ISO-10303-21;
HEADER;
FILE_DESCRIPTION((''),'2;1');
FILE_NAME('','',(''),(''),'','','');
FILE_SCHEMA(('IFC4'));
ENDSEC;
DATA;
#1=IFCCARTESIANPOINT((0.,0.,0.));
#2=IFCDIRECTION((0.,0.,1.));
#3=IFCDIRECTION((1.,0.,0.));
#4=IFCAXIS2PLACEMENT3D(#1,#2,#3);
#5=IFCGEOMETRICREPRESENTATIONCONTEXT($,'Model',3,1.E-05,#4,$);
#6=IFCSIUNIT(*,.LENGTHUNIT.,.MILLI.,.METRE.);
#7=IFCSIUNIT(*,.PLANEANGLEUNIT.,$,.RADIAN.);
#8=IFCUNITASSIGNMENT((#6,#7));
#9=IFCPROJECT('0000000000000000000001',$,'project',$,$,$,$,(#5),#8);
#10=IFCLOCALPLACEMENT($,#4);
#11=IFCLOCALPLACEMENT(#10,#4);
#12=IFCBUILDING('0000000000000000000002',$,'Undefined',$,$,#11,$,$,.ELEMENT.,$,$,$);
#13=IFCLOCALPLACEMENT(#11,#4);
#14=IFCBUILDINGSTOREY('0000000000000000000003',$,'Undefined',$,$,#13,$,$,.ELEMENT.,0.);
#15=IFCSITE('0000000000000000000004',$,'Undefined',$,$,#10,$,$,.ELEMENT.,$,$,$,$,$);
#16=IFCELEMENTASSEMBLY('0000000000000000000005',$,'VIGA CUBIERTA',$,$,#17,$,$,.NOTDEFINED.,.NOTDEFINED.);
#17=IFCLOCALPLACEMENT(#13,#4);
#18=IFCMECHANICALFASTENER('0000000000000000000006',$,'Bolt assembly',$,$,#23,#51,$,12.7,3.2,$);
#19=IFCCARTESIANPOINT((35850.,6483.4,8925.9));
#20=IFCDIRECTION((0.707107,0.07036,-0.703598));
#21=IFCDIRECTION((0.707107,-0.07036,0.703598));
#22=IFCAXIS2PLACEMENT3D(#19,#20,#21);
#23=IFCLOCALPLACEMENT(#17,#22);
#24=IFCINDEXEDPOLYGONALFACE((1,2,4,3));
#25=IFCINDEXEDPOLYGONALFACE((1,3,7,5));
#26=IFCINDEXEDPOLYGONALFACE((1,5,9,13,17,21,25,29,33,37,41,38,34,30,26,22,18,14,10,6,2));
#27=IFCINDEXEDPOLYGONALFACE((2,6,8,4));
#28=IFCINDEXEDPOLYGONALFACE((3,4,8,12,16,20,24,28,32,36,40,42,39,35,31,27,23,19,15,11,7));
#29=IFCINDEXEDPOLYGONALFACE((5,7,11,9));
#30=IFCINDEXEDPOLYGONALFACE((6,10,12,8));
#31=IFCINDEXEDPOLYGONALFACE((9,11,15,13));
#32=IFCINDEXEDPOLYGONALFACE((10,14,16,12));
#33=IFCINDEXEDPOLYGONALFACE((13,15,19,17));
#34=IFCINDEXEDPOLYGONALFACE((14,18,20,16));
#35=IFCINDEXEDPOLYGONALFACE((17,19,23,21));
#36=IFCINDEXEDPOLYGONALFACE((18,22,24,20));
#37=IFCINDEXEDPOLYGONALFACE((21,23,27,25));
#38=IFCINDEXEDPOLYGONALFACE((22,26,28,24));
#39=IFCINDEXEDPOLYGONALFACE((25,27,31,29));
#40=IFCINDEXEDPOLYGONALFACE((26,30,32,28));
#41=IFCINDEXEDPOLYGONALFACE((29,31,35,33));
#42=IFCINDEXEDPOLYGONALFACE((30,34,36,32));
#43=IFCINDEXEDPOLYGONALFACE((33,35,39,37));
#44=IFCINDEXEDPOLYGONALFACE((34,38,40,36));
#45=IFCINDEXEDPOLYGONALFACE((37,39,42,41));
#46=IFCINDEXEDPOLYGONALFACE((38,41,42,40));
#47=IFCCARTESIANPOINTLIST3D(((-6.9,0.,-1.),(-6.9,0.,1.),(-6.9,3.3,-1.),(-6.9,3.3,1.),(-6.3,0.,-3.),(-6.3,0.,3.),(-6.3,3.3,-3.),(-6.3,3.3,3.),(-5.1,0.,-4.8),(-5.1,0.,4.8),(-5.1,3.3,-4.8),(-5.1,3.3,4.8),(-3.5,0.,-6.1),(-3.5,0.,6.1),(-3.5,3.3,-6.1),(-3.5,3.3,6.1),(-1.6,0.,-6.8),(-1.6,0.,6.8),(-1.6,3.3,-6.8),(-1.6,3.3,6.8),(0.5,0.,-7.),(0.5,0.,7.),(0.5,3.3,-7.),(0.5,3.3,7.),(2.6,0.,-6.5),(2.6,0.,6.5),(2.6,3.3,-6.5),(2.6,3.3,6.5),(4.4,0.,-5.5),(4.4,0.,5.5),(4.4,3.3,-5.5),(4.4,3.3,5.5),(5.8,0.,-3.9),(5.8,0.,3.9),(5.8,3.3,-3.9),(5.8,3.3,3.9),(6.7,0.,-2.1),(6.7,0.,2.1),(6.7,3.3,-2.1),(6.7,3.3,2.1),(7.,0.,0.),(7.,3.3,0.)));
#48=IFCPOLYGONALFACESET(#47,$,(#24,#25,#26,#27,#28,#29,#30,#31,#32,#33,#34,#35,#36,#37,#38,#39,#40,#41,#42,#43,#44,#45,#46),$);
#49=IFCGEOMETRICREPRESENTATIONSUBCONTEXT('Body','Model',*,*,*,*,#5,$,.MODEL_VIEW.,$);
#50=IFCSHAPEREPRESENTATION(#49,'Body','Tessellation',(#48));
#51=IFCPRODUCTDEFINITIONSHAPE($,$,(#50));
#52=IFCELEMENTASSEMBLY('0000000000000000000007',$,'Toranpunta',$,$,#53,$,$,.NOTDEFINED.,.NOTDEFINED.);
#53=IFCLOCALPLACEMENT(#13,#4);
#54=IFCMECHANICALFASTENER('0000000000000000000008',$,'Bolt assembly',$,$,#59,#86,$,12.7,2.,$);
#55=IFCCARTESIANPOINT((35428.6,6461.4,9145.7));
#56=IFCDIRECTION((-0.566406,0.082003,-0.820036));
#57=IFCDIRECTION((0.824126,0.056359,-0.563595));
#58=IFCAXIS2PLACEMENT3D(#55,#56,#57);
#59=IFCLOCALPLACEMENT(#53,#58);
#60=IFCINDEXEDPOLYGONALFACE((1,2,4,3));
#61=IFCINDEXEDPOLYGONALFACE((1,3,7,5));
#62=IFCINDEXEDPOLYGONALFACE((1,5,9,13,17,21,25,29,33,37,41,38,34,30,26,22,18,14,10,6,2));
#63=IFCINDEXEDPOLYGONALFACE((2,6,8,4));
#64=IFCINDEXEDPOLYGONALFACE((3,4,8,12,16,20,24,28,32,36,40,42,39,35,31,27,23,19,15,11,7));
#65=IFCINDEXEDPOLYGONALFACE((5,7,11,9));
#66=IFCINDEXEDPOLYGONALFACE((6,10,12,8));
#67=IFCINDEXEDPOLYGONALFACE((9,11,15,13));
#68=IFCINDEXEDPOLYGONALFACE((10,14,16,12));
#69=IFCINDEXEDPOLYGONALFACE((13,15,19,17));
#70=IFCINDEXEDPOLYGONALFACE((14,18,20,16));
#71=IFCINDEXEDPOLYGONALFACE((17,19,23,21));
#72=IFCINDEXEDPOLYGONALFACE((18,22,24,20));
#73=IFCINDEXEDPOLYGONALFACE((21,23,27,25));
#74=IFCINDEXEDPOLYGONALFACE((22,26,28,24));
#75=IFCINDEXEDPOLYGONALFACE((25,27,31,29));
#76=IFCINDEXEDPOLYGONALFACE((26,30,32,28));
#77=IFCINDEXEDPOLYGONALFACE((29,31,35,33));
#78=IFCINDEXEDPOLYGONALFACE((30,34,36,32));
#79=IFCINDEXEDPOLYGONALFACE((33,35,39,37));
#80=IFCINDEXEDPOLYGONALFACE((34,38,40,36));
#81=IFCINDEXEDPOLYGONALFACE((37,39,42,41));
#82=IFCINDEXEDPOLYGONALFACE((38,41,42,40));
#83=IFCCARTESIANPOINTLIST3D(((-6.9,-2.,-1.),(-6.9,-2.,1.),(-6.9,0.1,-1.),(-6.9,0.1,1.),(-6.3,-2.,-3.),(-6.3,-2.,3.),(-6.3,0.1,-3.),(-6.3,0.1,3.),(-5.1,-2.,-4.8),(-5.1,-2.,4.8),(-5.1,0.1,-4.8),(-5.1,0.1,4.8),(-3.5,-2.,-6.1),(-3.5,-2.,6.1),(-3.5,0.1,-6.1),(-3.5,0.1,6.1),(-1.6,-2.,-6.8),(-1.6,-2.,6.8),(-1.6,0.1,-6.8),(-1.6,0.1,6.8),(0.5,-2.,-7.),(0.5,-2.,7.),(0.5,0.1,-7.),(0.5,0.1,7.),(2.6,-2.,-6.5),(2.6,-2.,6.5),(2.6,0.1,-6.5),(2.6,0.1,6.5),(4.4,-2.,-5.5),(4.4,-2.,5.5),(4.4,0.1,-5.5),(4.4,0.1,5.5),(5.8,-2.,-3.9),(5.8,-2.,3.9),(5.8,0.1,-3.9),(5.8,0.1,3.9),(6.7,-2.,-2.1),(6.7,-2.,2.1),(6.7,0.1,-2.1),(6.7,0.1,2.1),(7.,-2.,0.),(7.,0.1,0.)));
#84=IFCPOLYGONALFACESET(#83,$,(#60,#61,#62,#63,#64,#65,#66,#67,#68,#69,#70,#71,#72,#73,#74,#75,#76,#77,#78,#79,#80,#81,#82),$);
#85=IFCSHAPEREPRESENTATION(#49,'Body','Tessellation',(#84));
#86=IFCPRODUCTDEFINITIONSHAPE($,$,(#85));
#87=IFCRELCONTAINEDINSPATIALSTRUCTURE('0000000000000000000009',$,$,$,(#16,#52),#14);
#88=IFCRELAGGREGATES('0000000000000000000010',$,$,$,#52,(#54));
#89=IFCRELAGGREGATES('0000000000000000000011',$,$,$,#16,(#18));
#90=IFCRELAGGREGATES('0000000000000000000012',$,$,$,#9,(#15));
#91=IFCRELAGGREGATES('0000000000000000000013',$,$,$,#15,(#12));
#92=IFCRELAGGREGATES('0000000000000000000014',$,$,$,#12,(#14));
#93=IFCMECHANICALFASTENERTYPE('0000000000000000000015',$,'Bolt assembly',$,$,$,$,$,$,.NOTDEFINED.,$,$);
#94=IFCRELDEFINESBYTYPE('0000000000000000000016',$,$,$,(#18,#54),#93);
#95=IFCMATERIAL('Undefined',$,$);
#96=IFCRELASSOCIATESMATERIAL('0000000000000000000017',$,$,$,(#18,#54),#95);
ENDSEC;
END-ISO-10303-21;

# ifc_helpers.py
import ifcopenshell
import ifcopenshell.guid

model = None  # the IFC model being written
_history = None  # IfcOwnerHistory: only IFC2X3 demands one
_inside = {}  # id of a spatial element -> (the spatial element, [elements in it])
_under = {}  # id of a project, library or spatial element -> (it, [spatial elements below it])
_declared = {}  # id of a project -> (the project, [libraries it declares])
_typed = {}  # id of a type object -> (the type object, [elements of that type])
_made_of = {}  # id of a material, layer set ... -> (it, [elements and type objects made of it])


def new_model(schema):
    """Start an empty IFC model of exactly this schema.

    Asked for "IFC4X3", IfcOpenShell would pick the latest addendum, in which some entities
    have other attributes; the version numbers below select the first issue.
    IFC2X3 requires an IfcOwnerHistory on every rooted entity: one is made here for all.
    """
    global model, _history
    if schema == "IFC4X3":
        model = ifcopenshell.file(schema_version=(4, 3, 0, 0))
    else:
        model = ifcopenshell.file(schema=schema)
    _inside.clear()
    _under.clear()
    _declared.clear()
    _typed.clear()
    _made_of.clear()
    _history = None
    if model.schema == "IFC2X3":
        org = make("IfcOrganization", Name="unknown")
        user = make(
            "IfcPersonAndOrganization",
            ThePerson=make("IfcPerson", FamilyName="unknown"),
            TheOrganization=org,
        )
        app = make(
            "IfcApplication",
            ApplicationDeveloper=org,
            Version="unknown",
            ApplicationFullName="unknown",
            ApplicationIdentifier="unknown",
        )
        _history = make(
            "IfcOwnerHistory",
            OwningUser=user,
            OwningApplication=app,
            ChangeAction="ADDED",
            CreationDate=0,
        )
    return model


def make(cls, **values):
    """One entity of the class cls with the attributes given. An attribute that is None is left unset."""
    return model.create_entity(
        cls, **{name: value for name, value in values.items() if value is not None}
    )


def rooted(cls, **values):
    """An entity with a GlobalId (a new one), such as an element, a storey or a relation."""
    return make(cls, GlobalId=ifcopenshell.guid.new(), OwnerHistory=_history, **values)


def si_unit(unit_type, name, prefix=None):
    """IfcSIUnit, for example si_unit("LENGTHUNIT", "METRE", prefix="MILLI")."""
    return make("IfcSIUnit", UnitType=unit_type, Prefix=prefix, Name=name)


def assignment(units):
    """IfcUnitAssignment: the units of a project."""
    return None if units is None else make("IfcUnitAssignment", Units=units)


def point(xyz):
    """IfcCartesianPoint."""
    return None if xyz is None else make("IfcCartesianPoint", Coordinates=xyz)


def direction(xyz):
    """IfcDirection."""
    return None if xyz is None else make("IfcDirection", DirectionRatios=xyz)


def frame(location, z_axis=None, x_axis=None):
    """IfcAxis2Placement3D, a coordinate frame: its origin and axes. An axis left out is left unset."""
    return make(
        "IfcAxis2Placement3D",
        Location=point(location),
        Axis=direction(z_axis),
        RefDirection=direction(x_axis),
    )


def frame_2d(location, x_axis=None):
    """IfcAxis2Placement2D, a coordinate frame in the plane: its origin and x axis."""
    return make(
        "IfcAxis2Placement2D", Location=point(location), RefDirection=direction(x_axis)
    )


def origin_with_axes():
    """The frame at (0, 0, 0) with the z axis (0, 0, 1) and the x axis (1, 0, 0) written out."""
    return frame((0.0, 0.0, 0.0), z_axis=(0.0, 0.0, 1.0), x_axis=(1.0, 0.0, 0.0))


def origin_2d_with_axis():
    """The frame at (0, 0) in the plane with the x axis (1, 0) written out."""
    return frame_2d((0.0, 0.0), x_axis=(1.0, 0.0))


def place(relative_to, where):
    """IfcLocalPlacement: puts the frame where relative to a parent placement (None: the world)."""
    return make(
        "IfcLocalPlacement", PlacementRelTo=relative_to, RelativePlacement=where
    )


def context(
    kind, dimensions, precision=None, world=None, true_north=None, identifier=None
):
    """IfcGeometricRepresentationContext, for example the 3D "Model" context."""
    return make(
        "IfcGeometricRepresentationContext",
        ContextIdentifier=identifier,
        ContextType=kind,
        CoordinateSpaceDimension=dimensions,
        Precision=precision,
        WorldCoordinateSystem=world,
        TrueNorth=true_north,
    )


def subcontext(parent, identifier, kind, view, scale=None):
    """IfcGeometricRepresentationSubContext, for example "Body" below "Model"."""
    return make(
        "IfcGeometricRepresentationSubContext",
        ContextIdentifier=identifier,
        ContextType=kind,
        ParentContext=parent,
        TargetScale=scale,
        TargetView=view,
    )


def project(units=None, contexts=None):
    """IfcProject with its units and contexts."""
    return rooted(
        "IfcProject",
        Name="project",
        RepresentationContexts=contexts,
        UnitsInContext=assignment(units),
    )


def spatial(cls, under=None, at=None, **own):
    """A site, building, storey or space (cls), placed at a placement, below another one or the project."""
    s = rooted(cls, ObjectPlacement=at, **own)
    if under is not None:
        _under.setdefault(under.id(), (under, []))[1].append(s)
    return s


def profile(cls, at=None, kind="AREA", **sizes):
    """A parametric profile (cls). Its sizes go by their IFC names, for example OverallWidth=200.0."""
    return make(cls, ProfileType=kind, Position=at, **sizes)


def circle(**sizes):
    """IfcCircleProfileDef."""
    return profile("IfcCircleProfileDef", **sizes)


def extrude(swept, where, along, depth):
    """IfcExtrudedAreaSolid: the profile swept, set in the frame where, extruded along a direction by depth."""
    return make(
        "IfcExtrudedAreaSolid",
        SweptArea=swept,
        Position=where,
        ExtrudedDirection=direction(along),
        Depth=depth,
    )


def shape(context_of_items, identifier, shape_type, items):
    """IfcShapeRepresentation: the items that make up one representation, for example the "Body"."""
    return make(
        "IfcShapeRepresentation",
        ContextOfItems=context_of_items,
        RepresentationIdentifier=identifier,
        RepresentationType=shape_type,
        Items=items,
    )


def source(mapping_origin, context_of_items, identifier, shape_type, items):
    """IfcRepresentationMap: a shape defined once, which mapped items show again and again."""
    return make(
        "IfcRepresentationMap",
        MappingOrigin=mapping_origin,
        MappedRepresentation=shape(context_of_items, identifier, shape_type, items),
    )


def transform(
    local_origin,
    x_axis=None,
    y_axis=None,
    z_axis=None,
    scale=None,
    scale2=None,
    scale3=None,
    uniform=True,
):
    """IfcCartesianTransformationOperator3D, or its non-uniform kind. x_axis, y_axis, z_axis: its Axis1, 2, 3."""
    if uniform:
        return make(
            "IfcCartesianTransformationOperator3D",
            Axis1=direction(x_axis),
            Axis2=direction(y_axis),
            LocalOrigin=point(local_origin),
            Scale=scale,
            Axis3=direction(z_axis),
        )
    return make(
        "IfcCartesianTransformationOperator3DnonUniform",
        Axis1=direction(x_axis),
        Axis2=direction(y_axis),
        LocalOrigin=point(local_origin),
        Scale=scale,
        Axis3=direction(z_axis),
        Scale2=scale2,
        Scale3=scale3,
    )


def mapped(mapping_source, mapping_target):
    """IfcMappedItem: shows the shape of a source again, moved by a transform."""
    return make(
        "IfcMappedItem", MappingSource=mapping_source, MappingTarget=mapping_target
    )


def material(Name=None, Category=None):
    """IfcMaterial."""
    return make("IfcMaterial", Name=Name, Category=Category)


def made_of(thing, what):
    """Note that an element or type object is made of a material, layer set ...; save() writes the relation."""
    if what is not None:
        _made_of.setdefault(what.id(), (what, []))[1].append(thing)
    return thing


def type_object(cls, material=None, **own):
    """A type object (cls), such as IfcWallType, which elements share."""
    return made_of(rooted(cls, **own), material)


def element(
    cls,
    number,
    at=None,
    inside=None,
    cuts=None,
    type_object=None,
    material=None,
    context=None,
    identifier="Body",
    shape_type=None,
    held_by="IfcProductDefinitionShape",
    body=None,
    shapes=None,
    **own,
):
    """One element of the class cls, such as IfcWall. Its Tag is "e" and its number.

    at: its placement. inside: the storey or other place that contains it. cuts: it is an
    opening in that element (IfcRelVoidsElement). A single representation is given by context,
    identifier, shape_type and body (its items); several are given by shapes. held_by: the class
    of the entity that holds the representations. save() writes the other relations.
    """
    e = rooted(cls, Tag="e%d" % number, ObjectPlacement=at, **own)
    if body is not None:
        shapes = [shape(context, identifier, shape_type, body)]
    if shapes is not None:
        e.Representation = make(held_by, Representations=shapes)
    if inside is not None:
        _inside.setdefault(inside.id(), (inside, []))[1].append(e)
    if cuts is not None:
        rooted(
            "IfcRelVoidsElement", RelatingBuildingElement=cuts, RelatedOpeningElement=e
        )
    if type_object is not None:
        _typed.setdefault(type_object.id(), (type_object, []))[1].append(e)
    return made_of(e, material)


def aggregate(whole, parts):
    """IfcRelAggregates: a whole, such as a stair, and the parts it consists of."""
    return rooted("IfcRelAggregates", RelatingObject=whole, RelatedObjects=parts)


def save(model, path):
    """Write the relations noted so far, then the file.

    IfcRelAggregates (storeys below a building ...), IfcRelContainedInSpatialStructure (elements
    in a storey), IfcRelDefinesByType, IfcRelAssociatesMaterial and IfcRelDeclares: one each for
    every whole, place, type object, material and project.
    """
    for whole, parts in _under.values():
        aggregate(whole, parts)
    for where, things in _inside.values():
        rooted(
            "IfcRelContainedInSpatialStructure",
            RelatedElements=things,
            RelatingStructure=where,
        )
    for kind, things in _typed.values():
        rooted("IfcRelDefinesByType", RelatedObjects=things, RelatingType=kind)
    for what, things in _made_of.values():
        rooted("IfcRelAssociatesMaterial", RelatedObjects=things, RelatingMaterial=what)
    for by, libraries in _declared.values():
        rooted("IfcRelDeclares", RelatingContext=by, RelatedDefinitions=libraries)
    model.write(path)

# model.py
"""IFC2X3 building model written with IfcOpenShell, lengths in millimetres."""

from ifc_helpers import new_model, si_unit, frame, origin_with_axes, origin_2d_with_axis, place, context, subcontext, project, spatial, circle, extrude, source, transform, mapped, material, type_object, element, aggregate, save


model = new_model("IFC2X3")

# Units and contexts
model_context = context("Model", 3, precision=1e-05, world=origin_with_axes())
body_context = subcontext(model_context, "Body", "Model", "MODEL_VIEW")
ifc_project = project(units=[si_unit("LENGTHUNIT", "METRE", prefix="MILLI"), si_unit("PLANEANGLEUNIT", "RADIAN")], contexts=[model_context])

# Site, building, storey
site_placement = place(None, origin_with_axes())
site = spatial("IfcSite", under=ifc_project, at=site_placement, Name="Undefined", CompositionType="ELEMENT")
building_placement = place(site_placement, origin_with_axes())
building = spatial("IfcBuilding", under=site, at=building_placement, Name="Undefined", CompositionType="ELEMENT")
storey_placement = place(building_placement, origin_with_axes())
storey = spatial("IfcBuildingStorey", under=building, at=storey_placement, Name="Undefined", CompositionType="ELEMENT", Elevation=0.0)

# Element assembly
assembly_1_placement = place(storey_placement, origin_with_axes())
assembly_1 = element("IfcElementAssembly", 1, at=assembly_1_placement, inside=storey, Name="VIGA CUBIERTA", AssemblyPlace="NOTDEFINED", PredefinedType="NOTDEFINED")

# Mechanical fastener
ifc_material_1 = material(Name="Undefined")
mechanical_fastener_type = type_object("IfcMechanicalFastenerType", Name="Bolt assembly")
shared_shape_1 = source(origin_with_axes(), body_context, "Body", "SweptSolid", [
    extrude(circle(Radius=7.0, at=origin_2d_with_axis()), frame((0.0, 0.0, 0.0), z_axis=(0.0, 1.0, 0.0), x_axis=(1.0, 0.0, 0.0)), (0.0, 0.0, 1.0), 3.3),
])
mechanical_fastener_1_placement = place(assembly_1_placement, frame((35850.0, 6483.4, 8925.9), z_axis=(0.707107, 0.07036, -0.703598), x_axis=(0.707107, -0.07036, 0.703598)))
mechanical_fastener_1 = element("IfcMechanicalFastener", 2, at=mechanical_fastener_1_placement, type_object=mechanical_fastener_type, material=ifc_material_1, Name="Bolt assembly", NominalDiameter=12.7, NominalLength=3.2, context=body_context, shape_type="MappedRepresentation", body=[
    mapped(shared_shape_1, transform((0.0, 0.0, 0.0))),
])

# Element assembly, mechanical fastener
assembly_2_placement = place(storey_placement, origin_with_axes())
assembly_2 = element("IfcElementAssembly", 3, at=assembly_2_placement, inside=storey, Name="Toranpunta", AssemblyPlace="NOTDEFINED", PredefinedType="NOTDEFINED")
shared_shape_2 = source(origin_with_axes(), body_context, "Body", "SweptSolid", [
    extrude(circle(Radius=7.0, at=origin_2d_with_axis()), frame((0.0, -2.0, 0.0), z_axis=(0.0, 1.0, 0.0), x_axis=(1.0, 0.0, 0.0)), (0.0, 0.0, 1.0), 2.1),
])
mechanical_fastener_2_placement = place(assembly_2_placement, frame((35428.6, 6461.4, 9145.7), z_axis=(-0.566406, 0.082003, -0.820036), x_axis=(0.824126, 0.056359, -0.563595)))
mechanical_fastener_2 = element("IfcMechanicalFastener", 4, at=mechanical_fastener_2_placement, type_object=mechanical_fastener_type, material=ifc_material_1, Name="Bolt assembly", NominalDiameter=12.7, NominalLength=2.0, context=body_context, shape_type="MappedRepresentation", body=[
    mapped(shared_shape_2, transform((0.0, 0.0, 0.0))),
])
aggregate(assembly_2, [mechanical_fastener_2])

aggregate(assembly_1, [mechanical_fastener_1])

save(model, "model.ifc")
